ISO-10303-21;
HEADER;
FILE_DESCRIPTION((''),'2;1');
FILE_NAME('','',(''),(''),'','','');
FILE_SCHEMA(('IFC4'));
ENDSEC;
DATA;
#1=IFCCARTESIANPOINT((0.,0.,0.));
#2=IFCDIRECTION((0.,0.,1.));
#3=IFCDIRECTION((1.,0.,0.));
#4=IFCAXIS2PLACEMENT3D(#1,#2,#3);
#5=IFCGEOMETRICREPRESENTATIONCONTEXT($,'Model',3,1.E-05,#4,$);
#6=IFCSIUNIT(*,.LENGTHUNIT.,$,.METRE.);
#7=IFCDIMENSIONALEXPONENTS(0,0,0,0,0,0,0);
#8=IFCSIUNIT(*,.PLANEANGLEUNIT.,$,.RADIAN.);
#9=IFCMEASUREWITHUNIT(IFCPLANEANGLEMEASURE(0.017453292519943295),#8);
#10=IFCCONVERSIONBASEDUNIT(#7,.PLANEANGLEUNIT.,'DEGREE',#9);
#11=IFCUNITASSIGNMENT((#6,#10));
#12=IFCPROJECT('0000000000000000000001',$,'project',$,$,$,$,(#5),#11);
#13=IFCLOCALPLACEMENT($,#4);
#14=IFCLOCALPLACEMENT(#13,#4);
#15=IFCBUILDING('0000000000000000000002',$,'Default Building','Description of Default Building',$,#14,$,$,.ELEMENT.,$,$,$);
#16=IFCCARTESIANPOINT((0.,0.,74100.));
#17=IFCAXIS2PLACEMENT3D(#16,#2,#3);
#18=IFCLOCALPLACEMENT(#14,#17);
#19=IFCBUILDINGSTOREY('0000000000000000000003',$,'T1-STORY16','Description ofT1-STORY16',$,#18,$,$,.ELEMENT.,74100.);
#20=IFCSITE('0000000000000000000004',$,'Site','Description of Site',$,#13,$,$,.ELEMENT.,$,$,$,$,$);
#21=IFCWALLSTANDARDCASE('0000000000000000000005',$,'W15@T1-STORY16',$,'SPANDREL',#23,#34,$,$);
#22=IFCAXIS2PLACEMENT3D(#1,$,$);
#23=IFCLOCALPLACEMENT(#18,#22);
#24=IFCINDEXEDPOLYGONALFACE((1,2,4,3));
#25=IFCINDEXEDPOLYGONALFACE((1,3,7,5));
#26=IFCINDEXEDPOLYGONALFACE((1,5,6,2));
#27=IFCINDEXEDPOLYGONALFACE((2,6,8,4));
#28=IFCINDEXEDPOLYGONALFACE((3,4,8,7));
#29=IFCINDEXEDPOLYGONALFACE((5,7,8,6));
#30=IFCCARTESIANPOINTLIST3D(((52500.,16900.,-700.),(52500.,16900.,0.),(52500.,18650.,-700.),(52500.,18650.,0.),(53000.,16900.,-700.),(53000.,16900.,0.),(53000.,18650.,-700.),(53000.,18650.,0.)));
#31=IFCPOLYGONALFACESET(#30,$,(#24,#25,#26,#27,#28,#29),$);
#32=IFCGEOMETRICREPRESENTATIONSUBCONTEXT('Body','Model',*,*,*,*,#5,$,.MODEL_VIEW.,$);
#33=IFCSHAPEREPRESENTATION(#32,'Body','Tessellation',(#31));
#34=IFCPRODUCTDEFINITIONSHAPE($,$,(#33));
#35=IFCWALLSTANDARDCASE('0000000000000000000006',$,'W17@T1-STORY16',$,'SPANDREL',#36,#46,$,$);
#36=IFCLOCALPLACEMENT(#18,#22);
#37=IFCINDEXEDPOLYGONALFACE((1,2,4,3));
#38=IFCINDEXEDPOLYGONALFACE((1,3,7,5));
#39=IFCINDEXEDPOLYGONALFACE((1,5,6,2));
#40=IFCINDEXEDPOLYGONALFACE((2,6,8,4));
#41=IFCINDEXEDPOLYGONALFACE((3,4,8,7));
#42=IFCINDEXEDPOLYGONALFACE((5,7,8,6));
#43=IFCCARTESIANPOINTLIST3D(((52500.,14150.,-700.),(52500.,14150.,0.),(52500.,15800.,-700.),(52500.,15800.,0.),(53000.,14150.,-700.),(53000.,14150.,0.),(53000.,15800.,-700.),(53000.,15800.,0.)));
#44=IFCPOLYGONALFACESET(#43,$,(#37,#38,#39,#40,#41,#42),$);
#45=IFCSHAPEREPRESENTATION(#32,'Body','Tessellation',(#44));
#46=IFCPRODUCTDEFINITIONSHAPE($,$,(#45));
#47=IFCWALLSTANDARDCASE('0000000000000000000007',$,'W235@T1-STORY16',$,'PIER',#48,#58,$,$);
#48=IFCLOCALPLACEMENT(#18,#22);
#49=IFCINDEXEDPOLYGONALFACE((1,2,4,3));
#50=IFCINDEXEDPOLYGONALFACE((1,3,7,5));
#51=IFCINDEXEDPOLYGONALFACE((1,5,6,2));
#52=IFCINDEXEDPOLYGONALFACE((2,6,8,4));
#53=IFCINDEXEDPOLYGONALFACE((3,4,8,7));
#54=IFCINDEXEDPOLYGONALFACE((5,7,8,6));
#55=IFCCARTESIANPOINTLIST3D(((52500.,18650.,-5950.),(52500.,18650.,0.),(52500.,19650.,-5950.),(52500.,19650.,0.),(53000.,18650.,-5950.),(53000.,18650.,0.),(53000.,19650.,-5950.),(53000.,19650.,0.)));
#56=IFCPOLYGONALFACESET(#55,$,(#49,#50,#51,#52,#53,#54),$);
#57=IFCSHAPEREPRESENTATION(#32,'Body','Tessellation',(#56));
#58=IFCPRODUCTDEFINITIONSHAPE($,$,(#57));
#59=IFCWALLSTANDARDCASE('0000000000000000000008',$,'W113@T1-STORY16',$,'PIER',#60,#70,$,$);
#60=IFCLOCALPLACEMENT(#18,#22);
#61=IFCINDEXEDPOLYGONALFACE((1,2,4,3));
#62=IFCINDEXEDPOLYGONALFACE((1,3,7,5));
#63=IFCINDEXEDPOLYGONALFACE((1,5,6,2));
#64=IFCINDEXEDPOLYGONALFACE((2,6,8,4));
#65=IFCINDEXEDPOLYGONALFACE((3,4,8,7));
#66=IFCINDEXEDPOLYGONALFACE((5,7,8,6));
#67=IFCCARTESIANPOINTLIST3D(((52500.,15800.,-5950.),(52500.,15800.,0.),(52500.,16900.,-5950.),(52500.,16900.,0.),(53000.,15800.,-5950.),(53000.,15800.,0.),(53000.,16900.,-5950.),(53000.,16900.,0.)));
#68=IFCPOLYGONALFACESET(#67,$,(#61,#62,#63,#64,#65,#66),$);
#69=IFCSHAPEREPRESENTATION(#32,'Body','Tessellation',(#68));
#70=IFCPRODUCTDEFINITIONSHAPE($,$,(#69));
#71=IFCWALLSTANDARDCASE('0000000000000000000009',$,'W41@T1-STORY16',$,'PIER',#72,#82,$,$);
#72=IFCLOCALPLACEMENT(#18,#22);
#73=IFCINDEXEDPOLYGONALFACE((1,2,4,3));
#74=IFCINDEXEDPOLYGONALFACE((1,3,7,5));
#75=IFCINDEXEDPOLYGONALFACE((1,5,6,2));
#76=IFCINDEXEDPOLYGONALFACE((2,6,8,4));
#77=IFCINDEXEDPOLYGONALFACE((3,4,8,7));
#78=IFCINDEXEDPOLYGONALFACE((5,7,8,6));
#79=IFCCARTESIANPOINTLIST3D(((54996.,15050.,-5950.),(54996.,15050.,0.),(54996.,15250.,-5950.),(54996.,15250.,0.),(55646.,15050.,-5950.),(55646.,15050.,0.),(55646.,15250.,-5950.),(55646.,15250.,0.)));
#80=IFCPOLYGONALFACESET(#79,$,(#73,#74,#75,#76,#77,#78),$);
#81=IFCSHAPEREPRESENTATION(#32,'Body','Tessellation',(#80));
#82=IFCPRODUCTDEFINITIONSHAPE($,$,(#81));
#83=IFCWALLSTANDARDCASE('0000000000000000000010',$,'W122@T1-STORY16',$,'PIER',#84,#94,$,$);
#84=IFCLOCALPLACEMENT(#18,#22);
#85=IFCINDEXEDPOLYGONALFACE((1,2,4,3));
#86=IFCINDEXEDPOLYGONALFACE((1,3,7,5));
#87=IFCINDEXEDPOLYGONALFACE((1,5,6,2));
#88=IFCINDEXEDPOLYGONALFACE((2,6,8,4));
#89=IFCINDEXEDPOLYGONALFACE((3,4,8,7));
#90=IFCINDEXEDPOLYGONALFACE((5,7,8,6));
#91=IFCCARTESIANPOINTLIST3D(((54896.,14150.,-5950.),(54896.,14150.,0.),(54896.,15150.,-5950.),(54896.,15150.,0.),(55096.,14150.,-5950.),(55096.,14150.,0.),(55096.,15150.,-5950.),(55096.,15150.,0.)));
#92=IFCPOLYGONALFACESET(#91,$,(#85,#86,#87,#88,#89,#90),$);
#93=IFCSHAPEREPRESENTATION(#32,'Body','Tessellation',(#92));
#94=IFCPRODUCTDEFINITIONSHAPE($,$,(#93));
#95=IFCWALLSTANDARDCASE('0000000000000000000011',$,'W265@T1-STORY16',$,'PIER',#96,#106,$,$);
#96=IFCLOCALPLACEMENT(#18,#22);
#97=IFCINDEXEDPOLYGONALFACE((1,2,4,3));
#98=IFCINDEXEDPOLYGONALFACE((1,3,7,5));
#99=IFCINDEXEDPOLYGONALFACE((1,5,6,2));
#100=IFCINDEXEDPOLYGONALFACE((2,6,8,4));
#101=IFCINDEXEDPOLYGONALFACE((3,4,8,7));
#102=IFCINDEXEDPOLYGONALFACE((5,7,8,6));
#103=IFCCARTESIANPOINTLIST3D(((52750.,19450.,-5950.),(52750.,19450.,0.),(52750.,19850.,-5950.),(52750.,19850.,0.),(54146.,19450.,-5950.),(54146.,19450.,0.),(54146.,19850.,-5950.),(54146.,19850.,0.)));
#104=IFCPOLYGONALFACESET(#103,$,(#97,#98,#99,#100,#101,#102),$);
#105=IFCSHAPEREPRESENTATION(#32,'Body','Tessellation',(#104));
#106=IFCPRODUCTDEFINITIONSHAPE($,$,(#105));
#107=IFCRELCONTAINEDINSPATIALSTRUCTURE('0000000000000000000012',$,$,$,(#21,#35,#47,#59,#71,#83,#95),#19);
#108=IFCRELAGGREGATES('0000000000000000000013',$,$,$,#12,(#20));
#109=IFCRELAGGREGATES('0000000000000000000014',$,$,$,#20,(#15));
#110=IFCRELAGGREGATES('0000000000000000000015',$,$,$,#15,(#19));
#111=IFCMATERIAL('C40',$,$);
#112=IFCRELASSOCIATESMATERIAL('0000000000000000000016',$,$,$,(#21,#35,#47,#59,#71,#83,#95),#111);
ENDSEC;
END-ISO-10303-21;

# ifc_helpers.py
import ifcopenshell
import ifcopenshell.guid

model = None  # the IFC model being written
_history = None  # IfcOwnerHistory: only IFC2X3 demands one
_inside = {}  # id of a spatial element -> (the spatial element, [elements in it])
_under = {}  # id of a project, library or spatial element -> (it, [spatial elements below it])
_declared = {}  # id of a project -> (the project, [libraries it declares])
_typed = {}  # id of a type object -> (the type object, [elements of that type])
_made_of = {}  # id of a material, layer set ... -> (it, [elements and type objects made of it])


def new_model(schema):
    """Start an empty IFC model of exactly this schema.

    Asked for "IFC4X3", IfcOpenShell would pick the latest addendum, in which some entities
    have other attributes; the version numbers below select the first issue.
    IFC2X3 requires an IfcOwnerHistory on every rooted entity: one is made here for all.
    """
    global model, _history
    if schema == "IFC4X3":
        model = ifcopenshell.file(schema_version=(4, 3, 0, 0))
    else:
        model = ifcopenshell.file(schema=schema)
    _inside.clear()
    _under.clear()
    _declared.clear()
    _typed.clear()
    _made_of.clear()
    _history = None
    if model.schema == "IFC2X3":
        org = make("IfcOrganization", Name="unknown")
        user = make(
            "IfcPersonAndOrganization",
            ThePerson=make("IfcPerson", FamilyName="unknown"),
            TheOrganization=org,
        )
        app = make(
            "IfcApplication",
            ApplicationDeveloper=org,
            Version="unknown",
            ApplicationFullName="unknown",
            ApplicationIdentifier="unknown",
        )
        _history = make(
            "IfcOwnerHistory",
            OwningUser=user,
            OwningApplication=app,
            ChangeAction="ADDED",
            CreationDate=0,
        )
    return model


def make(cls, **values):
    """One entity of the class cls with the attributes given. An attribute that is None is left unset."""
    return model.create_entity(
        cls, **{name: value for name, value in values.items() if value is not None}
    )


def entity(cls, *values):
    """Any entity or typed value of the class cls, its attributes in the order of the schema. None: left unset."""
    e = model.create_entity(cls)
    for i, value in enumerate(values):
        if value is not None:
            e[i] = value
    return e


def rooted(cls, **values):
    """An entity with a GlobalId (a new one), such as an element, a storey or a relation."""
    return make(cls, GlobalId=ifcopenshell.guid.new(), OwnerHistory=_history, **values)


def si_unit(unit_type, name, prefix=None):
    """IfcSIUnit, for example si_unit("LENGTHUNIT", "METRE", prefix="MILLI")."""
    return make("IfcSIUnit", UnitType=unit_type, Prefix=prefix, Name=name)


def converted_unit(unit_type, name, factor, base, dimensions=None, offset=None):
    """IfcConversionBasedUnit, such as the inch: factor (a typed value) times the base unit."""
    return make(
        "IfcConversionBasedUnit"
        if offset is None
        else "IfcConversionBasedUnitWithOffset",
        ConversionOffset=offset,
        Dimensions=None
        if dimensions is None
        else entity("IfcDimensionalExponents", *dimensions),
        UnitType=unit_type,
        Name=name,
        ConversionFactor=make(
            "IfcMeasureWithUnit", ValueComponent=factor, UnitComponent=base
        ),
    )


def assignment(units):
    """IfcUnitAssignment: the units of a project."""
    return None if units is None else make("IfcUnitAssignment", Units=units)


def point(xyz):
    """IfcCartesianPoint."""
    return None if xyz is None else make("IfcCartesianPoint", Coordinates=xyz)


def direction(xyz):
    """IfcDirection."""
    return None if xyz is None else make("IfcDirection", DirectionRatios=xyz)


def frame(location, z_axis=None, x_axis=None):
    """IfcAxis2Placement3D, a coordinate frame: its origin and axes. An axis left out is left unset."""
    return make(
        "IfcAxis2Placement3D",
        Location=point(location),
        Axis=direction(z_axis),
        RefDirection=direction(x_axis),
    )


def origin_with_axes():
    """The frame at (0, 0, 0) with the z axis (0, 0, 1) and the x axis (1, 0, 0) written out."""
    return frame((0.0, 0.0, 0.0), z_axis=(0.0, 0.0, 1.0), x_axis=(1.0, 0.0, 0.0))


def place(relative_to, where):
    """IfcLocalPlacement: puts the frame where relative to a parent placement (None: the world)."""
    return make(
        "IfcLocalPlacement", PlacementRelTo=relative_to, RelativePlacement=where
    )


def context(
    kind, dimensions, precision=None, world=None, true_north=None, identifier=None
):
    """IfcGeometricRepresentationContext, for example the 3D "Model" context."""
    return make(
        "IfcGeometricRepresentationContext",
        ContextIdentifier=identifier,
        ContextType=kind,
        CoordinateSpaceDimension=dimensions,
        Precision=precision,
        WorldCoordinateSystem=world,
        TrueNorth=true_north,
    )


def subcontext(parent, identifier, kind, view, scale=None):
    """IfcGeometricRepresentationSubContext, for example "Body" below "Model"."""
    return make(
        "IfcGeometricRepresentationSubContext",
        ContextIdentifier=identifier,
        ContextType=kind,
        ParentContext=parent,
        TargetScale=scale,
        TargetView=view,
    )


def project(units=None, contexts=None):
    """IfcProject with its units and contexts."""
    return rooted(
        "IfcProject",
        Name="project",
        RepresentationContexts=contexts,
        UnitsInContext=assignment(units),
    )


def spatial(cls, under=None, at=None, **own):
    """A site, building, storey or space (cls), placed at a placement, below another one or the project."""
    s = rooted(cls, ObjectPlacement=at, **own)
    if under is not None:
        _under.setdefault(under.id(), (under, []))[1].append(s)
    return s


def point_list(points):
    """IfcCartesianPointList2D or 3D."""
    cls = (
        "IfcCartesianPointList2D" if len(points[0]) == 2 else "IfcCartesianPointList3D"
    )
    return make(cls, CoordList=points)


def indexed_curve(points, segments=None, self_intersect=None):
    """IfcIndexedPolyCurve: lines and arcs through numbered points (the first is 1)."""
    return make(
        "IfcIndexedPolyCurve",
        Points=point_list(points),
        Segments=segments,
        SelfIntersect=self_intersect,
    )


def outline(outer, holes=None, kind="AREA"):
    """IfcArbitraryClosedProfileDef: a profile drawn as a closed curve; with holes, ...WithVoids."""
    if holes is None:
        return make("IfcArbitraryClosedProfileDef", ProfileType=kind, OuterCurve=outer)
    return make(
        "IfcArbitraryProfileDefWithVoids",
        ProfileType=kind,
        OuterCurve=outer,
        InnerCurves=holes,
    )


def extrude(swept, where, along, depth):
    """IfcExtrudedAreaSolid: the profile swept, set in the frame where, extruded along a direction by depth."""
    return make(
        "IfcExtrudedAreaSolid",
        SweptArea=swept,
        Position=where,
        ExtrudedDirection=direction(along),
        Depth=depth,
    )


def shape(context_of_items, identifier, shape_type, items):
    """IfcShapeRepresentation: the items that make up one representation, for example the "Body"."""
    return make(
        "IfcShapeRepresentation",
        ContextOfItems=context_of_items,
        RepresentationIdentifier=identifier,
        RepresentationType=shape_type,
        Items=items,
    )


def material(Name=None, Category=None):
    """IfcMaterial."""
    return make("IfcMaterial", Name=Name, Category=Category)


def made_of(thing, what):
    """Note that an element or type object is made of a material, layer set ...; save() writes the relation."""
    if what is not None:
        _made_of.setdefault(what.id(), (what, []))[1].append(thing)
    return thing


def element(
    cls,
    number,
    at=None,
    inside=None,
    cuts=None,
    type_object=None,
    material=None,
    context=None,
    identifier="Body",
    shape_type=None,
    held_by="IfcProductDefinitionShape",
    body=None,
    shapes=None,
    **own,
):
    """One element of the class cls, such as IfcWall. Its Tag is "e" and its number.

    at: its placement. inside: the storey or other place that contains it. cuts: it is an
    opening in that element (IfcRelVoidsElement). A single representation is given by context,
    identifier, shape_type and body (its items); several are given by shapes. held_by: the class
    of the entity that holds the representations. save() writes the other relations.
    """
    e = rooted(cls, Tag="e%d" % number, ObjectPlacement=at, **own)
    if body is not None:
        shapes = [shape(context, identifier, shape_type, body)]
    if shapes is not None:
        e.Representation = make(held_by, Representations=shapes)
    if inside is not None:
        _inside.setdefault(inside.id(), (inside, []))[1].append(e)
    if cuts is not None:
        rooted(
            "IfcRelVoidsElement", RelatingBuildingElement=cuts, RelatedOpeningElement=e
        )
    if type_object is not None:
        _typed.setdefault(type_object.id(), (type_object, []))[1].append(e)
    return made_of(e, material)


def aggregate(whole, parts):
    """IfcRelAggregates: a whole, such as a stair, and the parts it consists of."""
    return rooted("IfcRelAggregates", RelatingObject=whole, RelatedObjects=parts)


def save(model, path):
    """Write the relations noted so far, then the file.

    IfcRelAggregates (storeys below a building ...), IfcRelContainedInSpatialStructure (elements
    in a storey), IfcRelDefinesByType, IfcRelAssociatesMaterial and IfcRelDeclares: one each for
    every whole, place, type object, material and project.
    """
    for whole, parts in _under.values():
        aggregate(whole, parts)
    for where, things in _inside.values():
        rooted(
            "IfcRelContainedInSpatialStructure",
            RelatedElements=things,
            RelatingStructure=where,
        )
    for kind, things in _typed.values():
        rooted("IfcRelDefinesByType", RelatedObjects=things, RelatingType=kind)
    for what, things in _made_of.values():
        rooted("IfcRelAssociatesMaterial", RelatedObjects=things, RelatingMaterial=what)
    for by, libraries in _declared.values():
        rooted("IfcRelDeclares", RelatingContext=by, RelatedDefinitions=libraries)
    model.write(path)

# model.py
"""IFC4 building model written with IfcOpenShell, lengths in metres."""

from ifc_helpers import new_model, entity, si_unit, converted_unit, frame, origin_with_axes, place, context, subcontext, project, spatial, indexed_curve, outline, extrude, material, element, save


model = new_model("IFC4")

# Units and contexts
model_context = context("Model", 3, precision=1e-05, world=origin_with_axes())
body_context = subcontext(model_context, "Body", "Model", "MODEL_VIEW")
ifc_project = project(units=[si_unit("LENGTHUNIT", "METRE"), converted_unit("PLANEANGLEUNIT", "DEGREE", entity("IfcPlaneAngleMeasure", 0.017453292519943295), si_unit("PLANEANGLEUNIT", "RADIAN"), dimensions=[0, 0, 0, 0, 0, 0, 0])], contexts=[model_context])

# Site, building, storey
site_placement = place(None, origin_with_axes())
site = spatial("IfcSite", under=ifc_project, at=site_placement, Name="Site", Description="Description of Site", CompositionType="ELEMENT")
building_placement = place(site_placement, origin_with_axes())
building = spatial("IfcBuilding", under=site, at=building_placement, Name="Default Building", Description="Description of Default Building", CompositionType="ELEMENT")
storey_placement = place(building_placement, frame((0.0, 0.0, 74100.0), z_axis=(0.0, 0.0, 1.0), x_axis=(1.0, 0.0, 0.0)))
storey = spatial("IfcBuildingStorey", under=building, at=storey_placement, Name="T1-STORY16", Description="Description ofT1-STORY16", CompositionType="ELEMENT", Elevation=74100.0)

# Shared definitions
ifc_material_1 = material(Name="C40")

# Walls
wall_1_placement = place(storey_placement, frame((52750.0, 16900.0, -700.0), z_axis=(0.0, 0.0, 1.0), x_axis=(0.0, 1.0, 0.0)))
element("IfcWallStandardCase", 1, at=wall_1_placement, inside=storey, material=ifc_material_1, Name="W15@T1-STORY16", ObjectType="SPANDREL", context=body_context, shape_type="SweptSolid", body=[
    extrude(outline(indexed_curve([(0.0, -250.0), (0.0, 250.0), (1750.0, 250.0), (1750.0, -250.0), (0.0, -250.0)], self_intersect=False)), origin_with_axes(), (0.0, 0.0, 1.0), 700.0),
])
wall_2_placement = place(storey_placement, frame((52750.0, 14150.0, -700.0), z_axis=(0.0, 0.0, 1.0), x_axis=(0.0, 1.0, 0.0)))
element("IfcWallStandardCase", 2, at=wall_2_placement, inside=storey, material=ifc_material_1, Name="W17@T1-STORY16", ObjectType="SPANDREL", context=body_context, shape_type="SweptSolid", body=[
    extrude(outline(indexed_curve([(0.0, -250.0), (0.0, 250.0), (1650.0, 250.0), (1650.0, -250.0), (0.0, -250.0)], self_intersect=False)), origin_with_axes(), (0.0, 0.0, 1.0), 700.0),
])
wall_3_placement = place(storey_placement, frame((52750.0, 18650.0, -5950.0), z_axis=(0.0, 0.0, 1.0), x_axis=(0.0, 1.0, 0.0)))
element("IfcWallStandardCase", 3, at=wall_3_placement, inside=storey, material=ifc_material_1, Name="W235@T1-STORY16", ObjectType="PIER", context=body_context, shape_type="SweptSolid", body=[
    extrude(outline(indexed_curve([(0.0, -250.0), (0.0, 250.0), (1000.0, 250.0), (1000.0, -250.0), (0.0, -250.0)], self_intersect=False)), origin_with_axes(), (0.0, 0.0, 1.0), 5950.0),
])
wall_4_placement = place(storey_placement, frame((52750.0, 15800.0, -5950.0), z_axis=(0.0, 0.0, 1.0), x_axis=(0.0, 1.0, 0.0)))
element("IfcWallStandardCase", 4, at=wall_4_placement, inside=storey, material=ifc_material_1, Name="W113@T1-STORY16", ObjectType="PIER", context=body_context, shape_type="SweptSolid", body=[
    extrude(outline(indexed_curve([(0.0, -250.0), (0.0, 250.0), (1100.0, 250.0), (1100.0, -250.0), (0.0, -250.0)], self_intersect=False)), origin_with_axes(), (0.0, 0.0, 1.0), 5950.0),
])
wall_5_placement = place(storey_placement, frame((54996.0, 15150.0, -5950.0), z_axis=(0.0, 0.0, 1.0), x_axis=(1.0, 0.0, 0.0)))
element("IfcWallStandardCase", 5, at=wall_5_placement, inside=storey, material=ifc_material_1, Name="W41@T1-STORY16", ObjectType="PIER", context=body_context, shape_type="SweptSolid", body=[
    extrude(outline(indexed_curve([(0.0, -100.0), (0.0, 100.0), (650.0, 100.0), (650.0, -100.0), (0.0, -100.0)], self_intersect=False)), origin_with_axes(), (0.0, 0.0, 1.0), 5950.0),
])
wall_6_placement = place(storey_placement, frame((54996.0, 14150.0, -5950.0), z_axis=(0.0, 0.0, 1.0), x_axis=(0.0, 1.0, 0.0)))
element("IfcWallStandardCase", 6, at=wall_6_placement, inside=storey, material=ifc_material_1, Name="W122@T1-STORY16", ObjectType="PIER", context=body_context, shape_type="SweptSolid", body=[
    extrude(outline(indexed_curve([(0.0, -100.0), (0.0, 100.0), (1000.0, 100.0), (1000.0, -100.0), (0.0, -100.0)], self_intersect=False)), origin_with_axes(), (0.0, 0.0, 1.0), 5950.0),
])
wall_7_placement = place(storey_placement, frame((52750.0, 19650.0, -5950.0), z_axis=(0.0, 0.0, 1.0), x_axis=(1.0, 0.0, 0.0)))
element("IfcWallStandardCase", 7, at=wall_7_placement, inside=storey, material=ifc_material_1, Name="W265@T1-STORY16", ObjectType="PIER", context=body_context, shape_type="SweptSolid", body=[
    extrude(outline(indexed_curve([(0.0, -200.0), (0.0, 200.0), (1396.0, 200.0), (1396.0, -200.0), (0.0, -200.0)], self_intersect=False)), origin_with_axes(), (0.0, 0.0, 1.0), 5950.0),
])

save(model, "model.ifc")
